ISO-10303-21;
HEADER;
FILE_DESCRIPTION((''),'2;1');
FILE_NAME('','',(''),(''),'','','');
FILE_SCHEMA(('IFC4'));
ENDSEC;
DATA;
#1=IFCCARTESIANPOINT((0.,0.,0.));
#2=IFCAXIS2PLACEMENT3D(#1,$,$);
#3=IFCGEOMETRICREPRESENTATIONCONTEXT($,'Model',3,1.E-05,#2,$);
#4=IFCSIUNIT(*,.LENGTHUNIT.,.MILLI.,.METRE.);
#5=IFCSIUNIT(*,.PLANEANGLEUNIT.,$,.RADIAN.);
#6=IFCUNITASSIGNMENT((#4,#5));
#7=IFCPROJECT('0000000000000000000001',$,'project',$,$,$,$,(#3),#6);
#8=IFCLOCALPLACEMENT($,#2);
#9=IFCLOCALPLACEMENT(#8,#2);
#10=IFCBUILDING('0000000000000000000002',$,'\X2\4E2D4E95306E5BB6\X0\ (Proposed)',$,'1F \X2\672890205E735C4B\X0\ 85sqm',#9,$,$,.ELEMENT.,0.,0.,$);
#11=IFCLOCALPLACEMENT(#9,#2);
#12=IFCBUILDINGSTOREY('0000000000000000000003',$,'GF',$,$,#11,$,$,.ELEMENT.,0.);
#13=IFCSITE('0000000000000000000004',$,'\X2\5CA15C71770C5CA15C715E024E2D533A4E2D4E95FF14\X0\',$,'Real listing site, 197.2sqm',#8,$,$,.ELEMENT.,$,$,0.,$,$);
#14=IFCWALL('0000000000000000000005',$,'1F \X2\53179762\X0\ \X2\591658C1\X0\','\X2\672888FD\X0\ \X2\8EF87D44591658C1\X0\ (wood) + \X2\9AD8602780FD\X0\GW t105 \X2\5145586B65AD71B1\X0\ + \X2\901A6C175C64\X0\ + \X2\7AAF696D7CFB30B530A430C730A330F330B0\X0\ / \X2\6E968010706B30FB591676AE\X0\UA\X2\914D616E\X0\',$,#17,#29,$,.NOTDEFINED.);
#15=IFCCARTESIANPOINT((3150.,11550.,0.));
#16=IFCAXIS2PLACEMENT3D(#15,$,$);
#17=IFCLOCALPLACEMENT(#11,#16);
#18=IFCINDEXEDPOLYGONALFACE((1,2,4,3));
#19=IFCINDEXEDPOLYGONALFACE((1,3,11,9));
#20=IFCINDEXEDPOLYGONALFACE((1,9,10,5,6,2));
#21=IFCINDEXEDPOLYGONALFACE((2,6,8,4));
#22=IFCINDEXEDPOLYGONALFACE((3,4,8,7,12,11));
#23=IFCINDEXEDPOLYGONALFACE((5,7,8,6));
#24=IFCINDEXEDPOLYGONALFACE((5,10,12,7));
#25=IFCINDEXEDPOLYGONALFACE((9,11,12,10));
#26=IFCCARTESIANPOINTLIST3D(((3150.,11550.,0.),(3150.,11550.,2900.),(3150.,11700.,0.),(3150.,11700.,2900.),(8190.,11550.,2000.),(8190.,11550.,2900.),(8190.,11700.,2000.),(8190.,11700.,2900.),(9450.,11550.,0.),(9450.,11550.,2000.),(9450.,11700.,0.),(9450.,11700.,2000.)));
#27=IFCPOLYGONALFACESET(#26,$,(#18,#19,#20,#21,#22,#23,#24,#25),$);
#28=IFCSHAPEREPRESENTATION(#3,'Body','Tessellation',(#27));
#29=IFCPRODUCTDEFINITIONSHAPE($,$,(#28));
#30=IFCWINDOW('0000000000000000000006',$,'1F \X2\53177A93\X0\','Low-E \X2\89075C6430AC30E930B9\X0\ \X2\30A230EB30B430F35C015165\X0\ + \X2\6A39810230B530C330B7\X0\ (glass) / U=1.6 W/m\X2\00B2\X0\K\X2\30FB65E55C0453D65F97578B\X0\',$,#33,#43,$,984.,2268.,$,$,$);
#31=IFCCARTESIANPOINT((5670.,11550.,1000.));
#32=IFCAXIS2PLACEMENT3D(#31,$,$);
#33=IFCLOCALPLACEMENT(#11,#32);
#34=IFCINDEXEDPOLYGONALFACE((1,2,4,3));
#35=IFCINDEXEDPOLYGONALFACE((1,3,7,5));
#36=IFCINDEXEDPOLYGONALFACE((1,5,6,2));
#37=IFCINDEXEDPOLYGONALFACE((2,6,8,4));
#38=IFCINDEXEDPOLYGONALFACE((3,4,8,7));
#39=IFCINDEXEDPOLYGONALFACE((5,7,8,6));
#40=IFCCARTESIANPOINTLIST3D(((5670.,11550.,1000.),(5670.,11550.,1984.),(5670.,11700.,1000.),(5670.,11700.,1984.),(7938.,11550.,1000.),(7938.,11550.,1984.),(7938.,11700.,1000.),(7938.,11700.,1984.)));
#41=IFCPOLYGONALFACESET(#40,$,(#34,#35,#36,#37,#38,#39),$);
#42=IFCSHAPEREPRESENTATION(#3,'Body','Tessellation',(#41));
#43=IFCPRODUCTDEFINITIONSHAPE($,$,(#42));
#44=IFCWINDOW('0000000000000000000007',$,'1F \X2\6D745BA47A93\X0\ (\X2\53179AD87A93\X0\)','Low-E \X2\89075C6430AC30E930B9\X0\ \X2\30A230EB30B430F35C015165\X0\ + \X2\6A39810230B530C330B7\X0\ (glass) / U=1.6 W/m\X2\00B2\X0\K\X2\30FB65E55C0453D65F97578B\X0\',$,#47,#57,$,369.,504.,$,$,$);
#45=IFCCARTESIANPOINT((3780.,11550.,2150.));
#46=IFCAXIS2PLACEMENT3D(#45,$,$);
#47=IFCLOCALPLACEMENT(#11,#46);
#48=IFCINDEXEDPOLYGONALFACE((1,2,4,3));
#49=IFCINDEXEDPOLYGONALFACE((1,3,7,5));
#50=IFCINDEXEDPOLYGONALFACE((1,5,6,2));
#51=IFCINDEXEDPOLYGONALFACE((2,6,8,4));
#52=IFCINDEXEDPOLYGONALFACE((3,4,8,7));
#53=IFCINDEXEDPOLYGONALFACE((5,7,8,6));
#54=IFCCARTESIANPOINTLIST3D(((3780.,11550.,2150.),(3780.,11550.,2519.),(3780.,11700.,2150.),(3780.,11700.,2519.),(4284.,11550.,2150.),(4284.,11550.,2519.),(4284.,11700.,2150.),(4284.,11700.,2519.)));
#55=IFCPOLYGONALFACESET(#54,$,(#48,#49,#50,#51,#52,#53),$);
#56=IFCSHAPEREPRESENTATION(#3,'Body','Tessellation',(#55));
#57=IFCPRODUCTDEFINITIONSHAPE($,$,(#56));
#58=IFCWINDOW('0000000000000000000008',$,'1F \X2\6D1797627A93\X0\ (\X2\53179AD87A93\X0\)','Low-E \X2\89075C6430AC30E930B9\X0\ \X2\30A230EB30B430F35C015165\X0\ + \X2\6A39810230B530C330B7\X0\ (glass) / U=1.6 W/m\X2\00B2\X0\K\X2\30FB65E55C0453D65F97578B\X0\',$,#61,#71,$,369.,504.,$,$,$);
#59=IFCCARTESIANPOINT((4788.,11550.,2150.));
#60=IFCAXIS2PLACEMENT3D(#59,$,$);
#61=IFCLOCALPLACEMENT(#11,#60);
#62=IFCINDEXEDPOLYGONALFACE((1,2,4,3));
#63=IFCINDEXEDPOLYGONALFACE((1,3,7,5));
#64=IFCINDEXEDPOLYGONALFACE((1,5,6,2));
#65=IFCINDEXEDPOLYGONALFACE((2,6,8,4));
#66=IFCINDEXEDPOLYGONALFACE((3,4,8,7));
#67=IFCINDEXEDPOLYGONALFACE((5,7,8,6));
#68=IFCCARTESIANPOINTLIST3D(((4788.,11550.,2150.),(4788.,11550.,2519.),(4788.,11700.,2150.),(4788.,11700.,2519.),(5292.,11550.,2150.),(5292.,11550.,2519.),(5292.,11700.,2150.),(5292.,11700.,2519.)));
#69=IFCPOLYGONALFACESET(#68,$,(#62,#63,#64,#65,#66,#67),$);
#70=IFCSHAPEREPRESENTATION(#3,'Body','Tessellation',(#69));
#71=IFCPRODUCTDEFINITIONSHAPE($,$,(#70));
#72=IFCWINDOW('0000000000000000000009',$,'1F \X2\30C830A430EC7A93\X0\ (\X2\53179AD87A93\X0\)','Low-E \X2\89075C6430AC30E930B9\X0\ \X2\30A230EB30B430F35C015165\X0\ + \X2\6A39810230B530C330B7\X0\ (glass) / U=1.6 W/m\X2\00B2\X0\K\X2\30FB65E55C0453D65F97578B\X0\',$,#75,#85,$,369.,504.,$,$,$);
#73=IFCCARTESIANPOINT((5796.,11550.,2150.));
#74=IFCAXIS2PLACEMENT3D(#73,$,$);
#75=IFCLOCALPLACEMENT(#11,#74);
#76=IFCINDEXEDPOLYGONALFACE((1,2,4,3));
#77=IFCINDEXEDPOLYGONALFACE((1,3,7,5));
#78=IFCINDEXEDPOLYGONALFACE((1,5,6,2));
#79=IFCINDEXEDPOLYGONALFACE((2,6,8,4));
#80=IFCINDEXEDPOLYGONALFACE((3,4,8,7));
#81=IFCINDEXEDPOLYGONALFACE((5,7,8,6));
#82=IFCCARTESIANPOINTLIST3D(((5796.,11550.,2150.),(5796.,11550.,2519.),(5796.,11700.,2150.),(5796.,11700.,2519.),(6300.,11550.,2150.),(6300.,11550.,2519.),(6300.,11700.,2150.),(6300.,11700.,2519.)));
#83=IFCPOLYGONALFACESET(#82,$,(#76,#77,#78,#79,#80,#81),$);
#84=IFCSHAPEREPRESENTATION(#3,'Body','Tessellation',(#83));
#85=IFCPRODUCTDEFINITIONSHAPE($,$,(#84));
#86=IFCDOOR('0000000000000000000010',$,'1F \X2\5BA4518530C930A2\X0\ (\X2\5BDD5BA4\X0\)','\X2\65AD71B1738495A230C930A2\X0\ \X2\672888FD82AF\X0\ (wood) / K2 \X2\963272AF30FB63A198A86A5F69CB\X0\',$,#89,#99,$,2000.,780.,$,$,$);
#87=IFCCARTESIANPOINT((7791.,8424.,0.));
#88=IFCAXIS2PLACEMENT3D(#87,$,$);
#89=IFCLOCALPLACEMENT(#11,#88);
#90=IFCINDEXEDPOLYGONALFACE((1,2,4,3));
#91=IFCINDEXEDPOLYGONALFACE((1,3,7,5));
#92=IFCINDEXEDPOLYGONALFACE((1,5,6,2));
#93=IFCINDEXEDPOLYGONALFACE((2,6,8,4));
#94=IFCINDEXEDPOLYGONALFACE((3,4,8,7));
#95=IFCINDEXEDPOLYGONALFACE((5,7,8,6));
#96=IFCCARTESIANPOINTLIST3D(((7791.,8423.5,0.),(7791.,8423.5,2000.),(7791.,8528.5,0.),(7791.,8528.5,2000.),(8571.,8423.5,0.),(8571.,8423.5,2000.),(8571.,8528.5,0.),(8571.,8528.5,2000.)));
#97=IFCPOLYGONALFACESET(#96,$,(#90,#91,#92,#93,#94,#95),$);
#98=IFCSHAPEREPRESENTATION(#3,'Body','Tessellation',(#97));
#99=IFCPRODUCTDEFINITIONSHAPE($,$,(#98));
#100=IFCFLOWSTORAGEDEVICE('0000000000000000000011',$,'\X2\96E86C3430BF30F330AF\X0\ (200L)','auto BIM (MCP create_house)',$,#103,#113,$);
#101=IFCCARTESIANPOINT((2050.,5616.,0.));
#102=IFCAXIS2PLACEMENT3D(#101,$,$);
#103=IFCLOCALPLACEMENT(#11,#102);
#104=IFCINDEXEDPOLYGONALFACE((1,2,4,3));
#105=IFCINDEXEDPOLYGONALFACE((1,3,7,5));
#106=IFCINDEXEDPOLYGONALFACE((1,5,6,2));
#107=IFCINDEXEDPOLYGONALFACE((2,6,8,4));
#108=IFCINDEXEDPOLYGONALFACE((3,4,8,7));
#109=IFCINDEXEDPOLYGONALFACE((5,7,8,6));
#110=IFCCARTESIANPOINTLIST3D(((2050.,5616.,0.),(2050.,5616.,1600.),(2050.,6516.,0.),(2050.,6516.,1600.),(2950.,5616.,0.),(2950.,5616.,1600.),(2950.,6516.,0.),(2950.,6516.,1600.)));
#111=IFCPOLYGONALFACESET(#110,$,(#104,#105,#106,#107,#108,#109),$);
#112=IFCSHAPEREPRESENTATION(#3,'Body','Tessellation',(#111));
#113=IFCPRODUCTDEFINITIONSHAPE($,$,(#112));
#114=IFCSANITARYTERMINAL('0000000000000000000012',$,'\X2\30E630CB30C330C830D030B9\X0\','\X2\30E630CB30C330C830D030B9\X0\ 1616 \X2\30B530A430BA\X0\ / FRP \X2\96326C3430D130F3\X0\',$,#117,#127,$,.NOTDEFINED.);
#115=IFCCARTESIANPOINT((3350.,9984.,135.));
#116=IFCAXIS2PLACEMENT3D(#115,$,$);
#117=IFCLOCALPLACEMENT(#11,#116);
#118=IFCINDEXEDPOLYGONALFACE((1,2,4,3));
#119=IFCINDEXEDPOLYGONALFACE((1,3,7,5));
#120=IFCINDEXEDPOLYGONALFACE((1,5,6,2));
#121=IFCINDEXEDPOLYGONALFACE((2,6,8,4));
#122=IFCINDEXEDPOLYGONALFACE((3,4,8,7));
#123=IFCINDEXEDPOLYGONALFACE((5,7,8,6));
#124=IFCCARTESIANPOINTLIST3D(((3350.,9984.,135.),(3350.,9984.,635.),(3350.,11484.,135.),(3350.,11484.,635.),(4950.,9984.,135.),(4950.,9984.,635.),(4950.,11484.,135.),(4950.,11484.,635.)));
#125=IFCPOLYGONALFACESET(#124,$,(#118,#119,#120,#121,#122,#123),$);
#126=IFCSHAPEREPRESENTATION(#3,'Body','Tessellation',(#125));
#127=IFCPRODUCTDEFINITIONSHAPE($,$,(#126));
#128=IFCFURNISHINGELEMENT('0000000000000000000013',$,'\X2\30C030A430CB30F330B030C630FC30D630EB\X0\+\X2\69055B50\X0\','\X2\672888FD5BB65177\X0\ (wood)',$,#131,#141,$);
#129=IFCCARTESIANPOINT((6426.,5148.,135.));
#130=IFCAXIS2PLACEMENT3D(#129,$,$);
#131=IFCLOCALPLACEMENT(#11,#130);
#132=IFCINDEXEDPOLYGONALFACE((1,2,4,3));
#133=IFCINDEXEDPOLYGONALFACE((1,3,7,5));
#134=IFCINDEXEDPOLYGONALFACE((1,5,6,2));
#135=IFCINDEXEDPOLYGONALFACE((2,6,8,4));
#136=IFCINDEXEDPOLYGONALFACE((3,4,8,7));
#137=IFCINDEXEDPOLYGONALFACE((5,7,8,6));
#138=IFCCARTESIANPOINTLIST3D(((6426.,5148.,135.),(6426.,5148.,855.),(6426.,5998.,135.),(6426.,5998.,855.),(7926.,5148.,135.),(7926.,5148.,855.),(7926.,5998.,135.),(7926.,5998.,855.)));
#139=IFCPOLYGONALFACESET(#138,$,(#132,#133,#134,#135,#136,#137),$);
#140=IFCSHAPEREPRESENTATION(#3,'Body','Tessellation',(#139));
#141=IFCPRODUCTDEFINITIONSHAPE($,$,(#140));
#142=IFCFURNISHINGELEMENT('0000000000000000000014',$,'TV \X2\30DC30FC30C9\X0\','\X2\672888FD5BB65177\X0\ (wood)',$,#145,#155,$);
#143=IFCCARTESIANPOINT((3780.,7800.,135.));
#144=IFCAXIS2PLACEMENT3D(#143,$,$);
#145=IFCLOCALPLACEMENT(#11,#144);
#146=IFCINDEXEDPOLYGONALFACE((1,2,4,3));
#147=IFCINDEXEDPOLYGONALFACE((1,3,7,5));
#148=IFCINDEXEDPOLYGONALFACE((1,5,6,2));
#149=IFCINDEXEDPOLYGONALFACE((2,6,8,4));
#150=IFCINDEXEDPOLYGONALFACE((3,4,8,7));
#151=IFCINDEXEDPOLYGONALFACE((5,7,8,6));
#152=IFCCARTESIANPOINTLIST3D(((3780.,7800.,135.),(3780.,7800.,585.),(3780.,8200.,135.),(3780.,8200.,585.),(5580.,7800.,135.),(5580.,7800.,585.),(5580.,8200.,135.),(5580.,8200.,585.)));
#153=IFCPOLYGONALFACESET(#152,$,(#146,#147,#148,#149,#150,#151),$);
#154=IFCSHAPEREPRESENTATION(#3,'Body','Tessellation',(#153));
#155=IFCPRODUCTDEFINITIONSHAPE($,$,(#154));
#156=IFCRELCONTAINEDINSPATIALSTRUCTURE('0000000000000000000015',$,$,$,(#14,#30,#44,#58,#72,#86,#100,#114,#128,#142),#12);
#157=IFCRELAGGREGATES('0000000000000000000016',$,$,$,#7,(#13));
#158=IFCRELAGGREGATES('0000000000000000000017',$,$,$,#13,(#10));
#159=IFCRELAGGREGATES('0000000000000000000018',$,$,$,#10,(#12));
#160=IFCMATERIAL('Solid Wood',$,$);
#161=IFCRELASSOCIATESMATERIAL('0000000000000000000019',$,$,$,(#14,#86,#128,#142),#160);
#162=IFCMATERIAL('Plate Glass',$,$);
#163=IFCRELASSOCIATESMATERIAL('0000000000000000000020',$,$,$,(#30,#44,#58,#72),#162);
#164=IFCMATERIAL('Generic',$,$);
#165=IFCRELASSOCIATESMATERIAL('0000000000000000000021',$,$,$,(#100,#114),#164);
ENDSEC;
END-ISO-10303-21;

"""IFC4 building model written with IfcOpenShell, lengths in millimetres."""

from ifc_helpers import new_model, si_unit, frame, frame_2d, origin, place, context, project, spatial, rectangle, extrude, material, element, fill, save


model = new_model("IFC4")

# Units and contexts
model_context = context("Model", 3, precision=1e-05, world=origin())
ifc_project = project(units=[si_unit("LENGTHUNIT", "METRE", prefix="MILLI"), si_unit("PLANEANGLEUNIT", "RADIAN")], contexts=[model_context])

# Site, building, storey
site_placement = place(None, origin())
site = spatial("IfcSite", under=ifc_project, at=site_placement, Name="岡山県岡山市中区中井４", ObjectType="Real listing site, 197.2sqm", CompositionType="ELEMENT", RefElevation=0.0)
building_placement = place(site_placement, origin())
building = spatial("IfcBuilding", under=site, at=building_placement, Name="中井の家 (Proposed)", ObjectType="1F 木造平屋 85sqm", CompositionType="ELEMENT", ElevationOfRefHeight=0.0, ElevationOfTerrain=0.0)
storey_placement = place(building_placement, origin())
storey = spatial("IfcBuildingStorey", under=building, at=storey_placement, Name="GF", CompositionType="ELEMENT", Elevation=0.0)

# Wall, openings, windows
ifc_material_1 = material(Name="Solid Wood")
wall_1_placement = place(storey_placement, frame((3150.0, 11550.0, 0.0)))
wall_1 = element("IfcWall", 1, at=wall_1_placement, inside=storey, material=ifc_material_1, Name="1F 北面 外壁", Description="木製 軸組外壁 (wood) + 高性能GW t105 充填断熱 + 通気層 + 窯業系サイディング / 準耐火・外皮UA配慮", PredefinedType="NOTDEFINED", context=model_context, shape_type="SweptSolid", body=[
    extrude(rectangle(XDim=6300.0, YDim=150.0, at=frame_2d((3150.0, 75.0))), frame((3150.0, 11550.0, 0.0)), (0.0, 0.0, 1.0), 2900.0),
])
opening_1_placement = place(storey_placement, frame((5670.0, 11550.0, 1000.0)))
opening_1 = element("IfcOpeningElement", 2, at=opening_1_placement, cuts=wall_1, PredefinedType="NOTDEFINED", context=model_context, shape_type="SweptSolid", body=[
    extrude(rectangle(XDim=2268.0, YDim=150.0, at=frame_2d((1134.0, 75.0))), frame((5670.0, 11550.0, 1000.0)), (0.0, 0.0, 1.0), 984.0),
])
opening_2_placement = place(storey_placement, frame((3780.0, 11550.0, 2150.0)))
opening_2 = element("IfcOpeningElement", 3, at=opening_2_placement, cuts=wall_1, PredefinedType="NOTDEFINED", context=model_context, shape_type="SweptSolid", body=[
    extrude(rectangle(XDim=504.0, YDim=150.0, at=frame_2d((252.0, 75.0))), frame((3780.0, 11550.0, 2150.0)), (0.0, 0.0, 1.0), 369.0),
])
opening_3_placement = place(storey_placement, frame((4788.0, 11550.0, 2150.0)))
opening_3 = element("IfcOpeningElement", 4, at=opening_3_placement, cuts=wall_1, PredefinedType="NOTDEFINED", context=model_context, shape_type="SweptSolid", body=[
    extrude(rectangle(XDim=504.0, YDim=150.0, at=frame_2d((252.0, 75.0))), frame((4788.0, 11550.0, 2150.0)), (0.0, 0.0, 1.0), 369.0),
])
opening_4_placement = place(storey_placement, frame((5796.0, 11550.0, 2150.0)))
opening_4 = element("IfcOpeningElement", 5, at=opening_4_placement, cuts=wall_1, PredefinedType="NOTDEFINED", context=model_context, shape_type="SweptSolid", body=[
    extrude(rectangle(XDim=504.0, YDim=150.0, at=frame_2d((252.0, 75.0))), frame((5796.0, 11550.0, 2150.0)), (0.0, 0.0, 1.0), 369.0),
])
ifc_material_2 = material(Name="Plate Glass")
window_1_placement = place(storey_placement, frame((5670.0, 11550.0, 1000.0)))
window_1 = element("IfcWindow", 6, at=window_1_placement, inside=storey, material=ifc_material_2, Name="1F 北窓", Description="Low-E 複層ガラス アルゴン封入 + 樹脂サッシ (glass) / U=1.6 W/m²K・日射取得型", OverallHeight=984.0, OverallWidth=2268.0, context=model_context, shape_type="SweptSolid", body=[
    extrude(rectangle(XDim=2268.0, YDim=150.0, at=frame_2d((1134.0, 75.0))), frame((5670.0, 11550.0, 1000.0)), (0.0, 0.0, 1.0), 984.0),
])
fill(opening_1, window_1)
window_2_placement = place(storey_placement, frame((3780.0, 11550.0, 2150.0)))
window_2 = element("IfcWindow", 7, at=window_2_placement, inside=storey, material=ifc_material_2, Name="1F 浴室窓 (北高窓)", Description="Low-E 複層ガラス アルゴン封入 + 樹脂サッシ (glass) / U=1.6 W/m²K・日射取得型", OverallHeight=369.0, OverallWidth=504.0, context=model_context, shape_type="SweptSolid", body=[
    extrude(rectangle(XDim=504.0, YDim=150.0, at=frame_2d((252.0, 75.0))), frame((3780.0, 11550.0, 2150.0)), (0.0, 0.0, 1.0), 369.0),
])
fill(opening_2, window_2)
window_3_placement = place(storey_placement, frame((4788.0, 11550.0, 2150.0)))
window_3 = element("IfcWindow", 8, at=window_3_placement, inside=storey, material=ifc_material_2, Name="1F 洗面窓 (北高窓)", Description="Low-E 複層ガラス アルゴン封入 + 樹脂サッシ (glass) / U=1.6 W/m²K・日射取得型", OverallHeight=369.0, OverallWidth=504.0, context=model_context, shape_type="SweptSolid", body=[
    extrude(rectangle(XDim=504.0, YDim=150.0, at=frame_2d((252.0, 75.0))), frame((4788.0, 11550.0, 2150.0)), (0.0, 0.0, 1.0), 369.0),
])
fill(opening_3, window_3)
window_4_placement = place(storey_placement, frame((5796.0, 11550.0, 2150.0)))
window_4 = element("IfcWindow", 9, at=window_4_placement, inside=storey, material=ifc_material_2, Name="1F トイレ窓 (北高窓)", Description="Low-E 複層ガラス アルゴン封入 + 樹脂サッシ (glass) / U=1.6 W/m²K・日射取得型", OverallHeight=369.0, OverallWidth=504.0, context=model_context, shape_type="SweptSolid", body=[
    extrude(rectangle(XDim=504.0, YDim=150.0, at=frame_2d((252.0, 75.0))), frame((5796.0, 11550.0, 2150.0)), (0.0, 0.0, 1.0), 369.0),
])
fill(opening_4, window_4)

# Door
door_1_placement = place(storey_placement, frame((7791.0, 8424.0, 0.0)))
element("IfcDoor", 10, at=door_1_placement, inside=storey, material=ifc_material_1, Name="1F 室内ドア (寝室)", Description="断熱玄関ドア 木製芯 (wood) / K2 防犯・採風機構", OverallHeight=2000.0, OverallWidth=780.0, context=model_context, shape_type="SweptSolid", body=[
    extrude(rectangle(XDim=780.0, YDim=105.0, at=frame_2d((390.0, 52.0))), frame((7791.0, 8424.0, 0.0)), (0.0, 0.0, 1.0), 2000.0),
])

# Flow storage device
ifc_material_3 = material(Name="Generic")
flow_storage_device_placement = place(storey_placement, frame((2050.0, 5616.0, 0.0)))
element("IfcFlowStorageDevice", 11, at=flow_storage_device_placement, inside=storey, material=ifc_material_3, Name="雨水タンク (200L)", Description="auto BIM (MCP create_house)", context=model_context, shape_type="SweptSolid", body=[
    extrude(rectangle(XDim=900.0, YDim=900.0, at=frame_2d((450.0, 450.0))), frame((2050.0, 5616.0, 0.0)), (0.0, 0.0, 1.0), 1600.0),
])

# Sanitary terminal
sanitary_terminal_placement = place(storey_placement, frame((3350.0, 9984.0, 135.0)))
element("IfcSanitaryTerminal", 12, at=sanitary_terminal_placement, inside=storey, material=ifc_material_3, Name="ユニットバス", Description="ユニットバス 1616 サイズ / FRP 防水パン", PredefinedType="NOTDEFINED", context=model_context, shape_type="SweptSolid", body=[
    extrude(rectangle(XDim=1600.0, YDim=1500.0, at=frame_2d((800.0, 750.0))), frame((3350.0, 9984.0, 135.0)), (0.0, 0.0, 1.0), 500.0),
])

# Furnishing elements
furnishing_1_placement = place(storey_placement, frame((6426.0, 5148.0, 135.0)))
element("IfcFurnishingElement", 13, at=furnishing_1_placement, inside=storey, material=ifc_material_1, Name="ダイニングテーブル+椅子", Description="木製家具 (wood)", context=model_context, shape_type="SweptSolid", body=[
    extrude(rectangle(XDim=1500.0, YDim=850.0, at=frame_2d((750.0, 425.0))), frame((6426.0, 5148.0, 135.0)), (0.0, 0.0, 1.0), 720.0),
])
furnishing_2_placement = place(storey_placement, frame((3780.0, 7800.0, 135.0)))
element("IfcFurnishingElement", 14, at=furnishing_2_placement, inside=storey, material=ifc_material_1, Name="TV ボード", Description="木製家具 (wood)", context=model_context, shape_type="SweptSolid", body=[
    extrude(rectangle(XDim=1800.0, YDim=400.0, at=frame_2d((900.0, 200.0))), frame((3780.0, 7800.0, 135.0)), (0.0, 0.0, 1.0), 450.0),
])

save(model, "model.ifc")
